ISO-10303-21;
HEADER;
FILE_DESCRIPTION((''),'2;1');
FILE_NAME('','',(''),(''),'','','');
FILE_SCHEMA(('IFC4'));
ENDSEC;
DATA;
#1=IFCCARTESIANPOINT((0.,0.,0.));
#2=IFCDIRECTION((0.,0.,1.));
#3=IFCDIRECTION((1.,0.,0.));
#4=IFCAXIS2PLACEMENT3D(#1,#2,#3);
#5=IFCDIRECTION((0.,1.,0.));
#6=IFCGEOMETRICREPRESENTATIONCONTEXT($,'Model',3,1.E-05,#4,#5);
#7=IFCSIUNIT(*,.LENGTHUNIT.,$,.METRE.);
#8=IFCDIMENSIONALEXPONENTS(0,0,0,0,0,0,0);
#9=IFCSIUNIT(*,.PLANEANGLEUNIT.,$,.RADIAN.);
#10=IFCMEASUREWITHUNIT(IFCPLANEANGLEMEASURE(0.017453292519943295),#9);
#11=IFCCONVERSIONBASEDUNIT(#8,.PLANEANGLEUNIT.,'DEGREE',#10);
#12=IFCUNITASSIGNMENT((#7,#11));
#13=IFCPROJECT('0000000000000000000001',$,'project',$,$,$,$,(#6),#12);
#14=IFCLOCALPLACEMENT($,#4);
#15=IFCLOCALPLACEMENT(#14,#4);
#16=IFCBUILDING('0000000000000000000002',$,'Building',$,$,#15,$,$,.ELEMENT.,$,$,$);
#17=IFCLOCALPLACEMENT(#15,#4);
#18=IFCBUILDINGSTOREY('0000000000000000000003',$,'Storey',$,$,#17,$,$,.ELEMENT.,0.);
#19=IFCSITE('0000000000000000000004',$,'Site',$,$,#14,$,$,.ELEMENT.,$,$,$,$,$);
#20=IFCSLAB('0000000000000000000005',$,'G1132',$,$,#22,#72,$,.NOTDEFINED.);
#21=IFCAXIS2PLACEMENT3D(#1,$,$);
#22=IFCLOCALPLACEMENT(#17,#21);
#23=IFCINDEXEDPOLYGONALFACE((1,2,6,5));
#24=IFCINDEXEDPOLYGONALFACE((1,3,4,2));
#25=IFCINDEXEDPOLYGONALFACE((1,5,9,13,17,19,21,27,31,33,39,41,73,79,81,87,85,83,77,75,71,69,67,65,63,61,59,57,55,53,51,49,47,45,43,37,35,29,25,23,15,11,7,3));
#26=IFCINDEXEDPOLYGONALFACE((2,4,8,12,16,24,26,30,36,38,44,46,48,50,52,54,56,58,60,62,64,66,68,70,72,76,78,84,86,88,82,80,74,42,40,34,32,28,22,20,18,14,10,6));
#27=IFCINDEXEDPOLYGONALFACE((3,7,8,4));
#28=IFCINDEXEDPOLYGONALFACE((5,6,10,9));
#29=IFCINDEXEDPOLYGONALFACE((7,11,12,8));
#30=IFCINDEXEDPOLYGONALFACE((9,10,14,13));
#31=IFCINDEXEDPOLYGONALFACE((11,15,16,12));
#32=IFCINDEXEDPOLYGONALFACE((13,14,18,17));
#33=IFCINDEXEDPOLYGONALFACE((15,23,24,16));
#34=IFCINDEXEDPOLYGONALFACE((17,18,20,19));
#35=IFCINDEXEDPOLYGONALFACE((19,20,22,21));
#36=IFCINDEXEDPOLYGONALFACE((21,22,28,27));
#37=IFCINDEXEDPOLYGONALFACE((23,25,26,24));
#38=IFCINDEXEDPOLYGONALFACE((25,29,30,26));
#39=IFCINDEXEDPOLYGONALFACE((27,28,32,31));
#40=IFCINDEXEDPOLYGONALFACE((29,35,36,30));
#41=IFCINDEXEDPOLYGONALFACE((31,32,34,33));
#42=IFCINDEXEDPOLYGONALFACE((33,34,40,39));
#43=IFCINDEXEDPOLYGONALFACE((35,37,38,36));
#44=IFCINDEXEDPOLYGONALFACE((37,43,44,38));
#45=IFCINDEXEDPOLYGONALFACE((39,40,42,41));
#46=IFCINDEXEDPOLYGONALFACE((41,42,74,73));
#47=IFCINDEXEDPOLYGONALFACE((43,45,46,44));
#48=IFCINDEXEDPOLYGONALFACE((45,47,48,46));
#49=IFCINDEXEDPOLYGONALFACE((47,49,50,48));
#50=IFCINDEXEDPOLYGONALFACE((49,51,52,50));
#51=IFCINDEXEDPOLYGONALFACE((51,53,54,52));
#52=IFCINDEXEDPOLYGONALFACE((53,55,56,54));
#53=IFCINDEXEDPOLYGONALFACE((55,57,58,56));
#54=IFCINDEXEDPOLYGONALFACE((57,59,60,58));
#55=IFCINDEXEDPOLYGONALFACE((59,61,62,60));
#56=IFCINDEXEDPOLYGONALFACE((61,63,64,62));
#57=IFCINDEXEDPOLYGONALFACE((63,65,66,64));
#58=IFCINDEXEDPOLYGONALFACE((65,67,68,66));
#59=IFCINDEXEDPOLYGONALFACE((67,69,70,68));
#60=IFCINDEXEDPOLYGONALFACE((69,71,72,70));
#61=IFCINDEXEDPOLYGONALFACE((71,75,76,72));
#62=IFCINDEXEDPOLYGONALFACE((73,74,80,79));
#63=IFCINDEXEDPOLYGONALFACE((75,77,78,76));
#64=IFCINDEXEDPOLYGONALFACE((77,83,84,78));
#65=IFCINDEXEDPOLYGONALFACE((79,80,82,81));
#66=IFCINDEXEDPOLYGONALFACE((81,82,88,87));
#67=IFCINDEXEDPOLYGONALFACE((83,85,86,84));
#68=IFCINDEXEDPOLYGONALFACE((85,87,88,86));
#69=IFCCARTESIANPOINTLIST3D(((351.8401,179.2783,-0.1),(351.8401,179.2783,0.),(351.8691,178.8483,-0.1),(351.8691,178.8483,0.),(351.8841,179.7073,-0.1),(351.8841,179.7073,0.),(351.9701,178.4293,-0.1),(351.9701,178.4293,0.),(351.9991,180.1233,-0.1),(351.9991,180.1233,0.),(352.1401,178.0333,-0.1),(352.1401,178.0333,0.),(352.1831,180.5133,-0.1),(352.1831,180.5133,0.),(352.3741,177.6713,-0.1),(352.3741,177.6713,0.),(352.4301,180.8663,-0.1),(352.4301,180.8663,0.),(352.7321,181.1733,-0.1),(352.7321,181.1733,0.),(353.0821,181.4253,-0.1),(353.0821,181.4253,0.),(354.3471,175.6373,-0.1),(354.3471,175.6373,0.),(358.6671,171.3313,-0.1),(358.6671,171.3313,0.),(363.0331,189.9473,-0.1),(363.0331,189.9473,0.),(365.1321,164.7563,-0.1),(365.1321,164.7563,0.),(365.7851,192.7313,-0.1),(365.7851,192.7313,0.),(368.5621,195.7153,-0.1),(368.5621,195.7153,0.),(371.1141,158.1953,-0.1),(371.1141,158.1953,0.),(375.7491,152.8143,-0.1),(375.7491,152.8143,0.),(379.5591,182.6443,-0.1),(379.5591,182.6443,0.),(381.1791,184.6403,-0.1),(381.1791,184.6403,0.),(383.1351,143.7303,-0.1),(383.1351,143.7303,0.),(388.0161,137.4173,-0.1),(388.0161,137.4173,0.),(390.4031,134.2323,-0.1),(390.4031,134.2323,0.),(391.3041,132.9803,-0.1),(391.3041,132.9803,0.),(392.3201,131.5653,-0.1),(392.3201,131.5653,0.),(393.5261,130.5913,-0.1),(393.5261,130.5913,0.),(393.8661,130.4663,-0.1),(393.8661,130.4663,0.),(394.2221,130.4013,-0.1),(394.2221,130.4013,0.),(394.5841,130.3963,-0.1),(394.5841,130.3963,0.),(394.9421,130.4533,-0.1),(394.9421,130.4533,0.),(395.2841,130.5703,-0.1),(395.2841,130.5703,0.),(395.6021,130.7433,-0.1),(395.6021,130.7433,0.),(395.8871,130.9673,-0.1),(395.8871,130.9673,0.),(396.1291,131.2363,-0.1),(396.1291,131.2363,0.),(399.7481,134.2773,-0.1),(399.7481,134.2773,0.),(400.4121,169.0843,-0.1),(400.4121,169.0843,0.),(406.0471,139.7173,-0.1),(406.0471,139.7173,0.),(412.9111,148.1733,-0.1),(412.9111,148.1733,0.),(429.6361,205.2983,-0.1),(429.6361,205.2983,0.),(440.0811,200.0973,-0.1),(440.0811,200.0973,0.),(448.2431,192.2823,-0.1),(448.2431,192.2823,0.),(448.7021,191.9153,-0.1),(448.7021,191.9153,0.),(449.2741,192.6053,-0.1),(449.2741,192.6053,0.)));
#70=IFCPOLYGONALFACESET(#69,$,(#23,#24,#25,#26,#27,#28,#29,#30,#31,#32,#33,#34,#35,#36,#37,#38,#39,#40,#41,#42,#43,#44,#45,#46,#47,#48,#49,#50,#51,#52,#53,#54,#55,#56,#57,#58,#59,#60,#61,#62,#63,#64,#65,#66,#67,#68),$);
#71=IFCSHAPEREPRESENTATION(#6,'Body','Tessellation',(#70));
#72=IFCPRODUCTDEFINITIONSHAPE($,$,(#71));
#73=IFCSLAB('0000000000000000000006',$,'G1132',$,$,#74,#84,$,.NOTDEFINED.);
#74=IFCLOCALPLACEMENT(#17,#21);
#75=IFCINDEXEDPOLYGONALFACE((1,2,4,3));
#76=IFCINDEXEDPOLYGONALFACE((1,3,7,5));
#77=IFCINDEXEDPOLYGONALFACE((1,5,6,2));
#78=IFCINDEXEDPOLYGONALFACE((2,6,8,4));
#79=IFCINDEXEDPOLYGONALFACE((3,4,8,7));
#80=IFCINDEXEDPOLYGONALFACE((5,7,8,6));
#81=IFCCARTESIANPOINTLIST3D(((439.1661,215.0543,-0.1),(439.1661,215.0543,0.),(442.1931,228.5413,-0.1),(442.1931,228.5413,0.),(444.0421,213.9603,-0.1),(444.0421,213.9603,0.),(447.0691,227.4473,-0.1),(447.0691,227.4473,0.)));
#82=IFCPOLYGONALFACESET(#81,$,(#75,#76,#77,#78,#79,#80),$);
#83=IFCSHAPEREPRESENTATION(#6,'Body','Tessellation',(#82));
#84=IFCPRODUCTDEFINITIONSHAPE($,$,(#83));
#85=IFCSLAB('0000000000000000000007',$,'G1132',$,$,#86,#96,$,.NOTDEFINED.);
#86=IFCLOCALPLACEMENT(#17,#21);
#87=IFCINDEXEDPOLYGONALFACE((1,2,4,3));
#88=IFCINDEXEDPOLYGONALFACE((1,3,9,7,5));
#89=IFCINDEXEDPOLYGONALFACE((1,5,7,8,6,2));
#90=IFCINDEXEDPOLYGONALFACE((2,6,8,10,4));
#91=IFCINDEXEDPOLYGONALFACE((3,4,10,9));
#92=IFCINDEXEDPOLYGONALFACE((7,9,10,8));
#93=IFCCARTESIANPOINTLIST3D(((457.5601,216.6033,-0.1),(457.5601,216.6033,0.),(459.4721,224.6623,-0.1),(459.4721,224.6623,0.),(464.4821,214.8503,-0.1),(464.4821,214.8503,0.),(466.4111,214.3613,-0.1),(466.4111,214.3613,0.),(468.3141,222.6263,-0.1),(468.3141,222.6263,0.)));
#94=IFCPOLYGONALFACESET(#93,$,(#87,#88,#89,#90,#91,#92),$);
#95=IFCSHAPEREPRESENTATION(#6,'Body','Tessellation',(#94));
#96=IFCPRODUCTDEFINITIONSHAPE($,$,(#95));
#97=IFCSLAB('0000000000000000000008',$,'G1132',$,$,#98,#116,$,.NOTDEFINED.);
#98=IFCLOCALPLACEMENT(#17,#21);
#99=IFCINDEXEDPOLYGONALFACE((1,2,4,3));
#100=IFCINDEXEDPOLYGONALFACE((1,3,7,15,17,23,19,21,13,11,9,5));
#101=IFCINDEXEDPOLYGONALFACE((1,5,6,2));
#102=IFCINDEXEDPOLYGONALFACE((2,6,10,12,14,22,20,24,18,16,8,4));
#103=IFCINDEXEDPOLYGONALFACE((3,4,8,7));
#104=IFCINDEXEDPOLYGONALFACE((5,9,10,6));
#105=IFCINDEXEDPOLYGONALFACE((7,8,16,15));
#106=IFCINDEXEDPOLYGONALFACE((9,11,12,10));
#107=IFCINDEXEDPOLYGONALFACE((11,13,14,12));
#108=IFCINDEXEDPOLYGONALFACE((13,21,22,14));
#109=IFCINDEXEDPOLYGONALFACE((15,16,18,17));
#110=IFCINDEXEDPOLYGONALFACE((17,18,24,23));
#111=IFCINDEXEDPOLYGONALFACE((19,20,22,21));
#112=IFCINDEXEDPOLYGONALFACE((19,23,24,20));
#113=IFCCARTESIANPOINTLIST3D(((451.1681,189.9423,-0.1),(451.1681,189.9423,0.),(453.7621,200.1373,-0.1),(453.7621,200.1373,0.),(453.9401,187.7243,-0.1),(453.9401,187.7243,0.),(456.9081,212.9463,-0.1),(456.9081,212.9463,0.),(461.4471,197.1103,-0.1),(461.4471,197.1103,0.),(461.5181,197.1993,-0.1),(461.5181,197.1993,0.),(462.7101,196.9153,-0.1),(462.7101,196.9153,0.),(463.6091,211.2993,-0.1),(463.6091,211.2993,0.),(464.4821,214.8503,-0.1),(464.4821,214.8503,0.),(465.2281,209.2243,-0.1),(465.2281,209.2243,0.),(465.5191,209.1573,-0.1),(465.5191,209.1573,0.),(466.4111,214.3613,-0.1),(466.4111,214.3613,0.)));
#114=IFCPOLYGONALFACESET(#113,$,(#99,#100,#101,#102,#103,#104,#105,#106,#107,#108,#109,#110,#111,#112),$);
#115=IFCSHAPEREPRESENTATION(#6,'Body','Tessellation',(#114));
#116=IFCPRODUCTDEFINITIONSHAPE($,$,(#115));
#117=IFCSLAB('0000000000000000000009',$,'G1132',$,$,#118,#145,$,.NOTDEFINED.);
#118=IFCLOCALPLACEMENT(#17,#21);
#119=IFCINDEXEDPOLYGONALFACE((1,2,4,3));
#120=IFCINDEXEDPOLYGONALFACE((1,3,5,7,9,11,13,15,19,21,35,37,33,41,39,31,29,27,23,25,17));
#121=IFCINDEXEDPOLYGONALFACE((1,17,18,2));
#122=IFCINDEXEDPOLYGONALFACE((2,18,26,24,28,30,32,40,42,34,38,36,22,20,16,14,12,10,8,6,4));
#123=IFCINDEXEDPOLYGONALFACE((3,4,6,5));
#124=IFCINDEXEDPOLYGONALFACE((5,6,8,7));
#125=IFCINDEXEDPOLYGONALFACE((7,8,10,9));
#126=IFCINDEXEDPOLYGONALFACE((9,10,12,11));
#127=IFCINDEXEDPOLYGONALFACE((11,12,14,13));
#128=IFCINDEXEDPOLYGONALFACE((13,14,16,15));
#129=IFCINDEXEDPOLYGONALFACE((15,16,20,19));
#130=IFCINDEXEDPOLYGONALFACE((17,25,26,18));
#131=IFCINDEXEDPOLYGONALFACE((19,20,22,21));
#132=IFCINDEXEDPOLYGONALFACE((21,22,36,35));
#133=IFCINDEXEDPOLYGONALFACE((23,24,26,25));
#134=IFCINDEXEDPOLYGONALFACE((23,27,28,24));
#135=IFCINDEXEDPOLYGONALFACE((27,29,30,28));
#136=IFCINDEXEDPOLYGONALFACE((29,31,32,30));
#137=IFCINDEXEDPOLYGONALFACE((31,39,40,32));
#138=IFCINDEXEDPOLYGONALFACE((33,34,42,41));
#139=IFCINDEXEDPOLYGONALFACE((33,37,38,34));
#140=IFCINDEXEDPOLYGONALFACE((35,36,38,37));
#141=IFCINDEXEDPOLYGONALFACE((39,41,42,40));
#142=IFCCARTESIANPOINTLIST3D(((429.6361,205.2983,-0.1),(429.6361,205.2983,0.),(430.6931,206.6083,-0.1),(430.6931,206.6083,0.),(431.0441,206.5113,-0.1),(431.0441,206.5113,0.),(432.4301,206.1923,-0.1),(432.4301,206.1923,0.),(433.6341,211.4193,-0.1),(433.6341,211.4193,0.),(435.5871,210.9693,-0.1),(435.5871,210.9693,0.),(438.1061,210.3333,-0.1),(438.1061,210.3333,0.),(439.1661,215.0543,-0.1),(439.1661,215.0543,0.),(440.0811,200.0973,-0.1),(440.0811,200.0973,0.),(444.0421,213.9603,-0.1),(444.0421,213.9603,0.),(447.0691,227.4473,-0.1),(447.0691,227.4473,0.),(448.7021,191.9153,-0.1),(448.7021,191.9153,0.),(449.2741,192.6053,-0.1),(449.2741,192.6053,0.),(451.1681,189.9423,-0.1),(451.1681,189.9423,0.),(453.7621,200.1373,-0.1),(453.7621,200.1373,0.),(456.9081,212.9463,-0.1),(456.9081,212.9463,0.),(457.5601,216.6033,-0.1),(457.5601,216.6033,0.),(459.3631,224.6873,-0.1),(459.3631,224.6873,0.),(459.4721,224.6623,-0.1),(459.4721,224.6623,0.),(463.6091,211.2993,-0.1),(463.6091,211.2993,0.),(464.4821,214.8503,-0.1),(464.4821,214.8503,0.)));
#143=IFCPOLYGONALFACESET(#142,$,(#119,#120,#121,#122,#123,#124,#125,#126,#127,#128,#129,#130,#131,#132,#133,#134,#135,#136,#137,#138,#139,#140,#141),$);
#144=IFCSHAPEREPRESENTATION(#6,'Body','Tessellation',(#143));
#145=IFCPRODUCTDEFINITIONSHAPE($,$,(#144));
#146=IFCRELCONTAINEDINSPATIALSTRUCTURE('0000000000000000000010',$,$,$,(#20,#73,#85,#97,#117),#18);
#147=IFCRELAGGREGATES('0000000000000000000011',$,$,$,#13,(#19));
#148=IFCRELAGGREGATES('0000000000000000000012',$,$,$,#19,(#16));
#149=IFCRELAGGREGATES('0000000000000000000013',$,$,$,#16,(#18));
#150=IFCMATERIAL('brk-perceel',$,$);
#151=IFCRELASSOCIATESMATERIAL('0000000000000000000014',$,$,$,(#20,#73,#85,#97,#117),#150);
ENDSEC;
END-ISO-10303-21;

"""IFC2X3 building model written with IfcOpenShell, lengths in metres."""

from ifc_helpers import new_model, entity, si_unit, converted_unit, direction, frame, origin_with_axes, place, context, project, spatial, polyline, outline, extrude, material, element, save


model = new_model("IFC2X3")

# Units and contexts
model_context = context("Model", 3, precision=1e-05, world=origin_with_axes(), true_north=direction((0.0, 1.0, 0.0)))
ifc_project = project(units=[si_unit("LENGTHUNIT", "METRE"), converted_unit("PLANEANGLEUNIT", "DEGREE", entity("IfcPlaneAngleMeasure", 0.017453292519943295), si_unit("PLANEANGLEUNIT", "RADIAN"), dimensions=[0, 0, 0, 0, 0, 0, 0])], contexts=[model_context])

# Site, building, storey
site_placement = place(None, origin_with_axes())
site = spatial("IfcSite", under=ifc_project, at=site_placement, Name="Site", CompositionType="ELEMENT")
building_placement = place(site_placement, origin_with_axes())
building = spatial("IfcBuilding", under=site, at=building_placement, Name="Building", CompositionType="ELEMENT")
storey_placement = place(building_placement, origin_with_axes())
storey = spatial("IfcBuildingStorey", under=building, at=storey_placement, Name="Storey", CompositionType="ELEMENT", Elevation=0.0)

# Slabs
ifc_material = material(Name="brk-perceel")
slab_1_placement = place(storey_placement, frame((0.0, 0.0, -0.1), z_axis=(0.0, 0.0, 1.0), x_axis=(1.0, 0.0, 0.0)))
element("IfcSlab", 1, at=slab_1_placement, inside=storey, material=ifc_material, Name="G1132", PredefinedType="NOTDEFINED", context=model_context, shape_type="SweptSolid", body=[
    extrude(outline(polyline([(448.2431, 192.2823), (412.9111, 148.1733), (406.0471, 139.7173), (399.7481, 134.2773), (396.1291, 131.2363), (395.8871, 130.9673), (395.6021, 130.7433), (395.2841, 130.5703), (394.9421, 130.4533), (394.5841, 130.3963), (394.2221, 130.4013), (393.8661, 130.4663), (393.5261, 130.5913), (392.3201, 131.5653), (391.3041, 132.9803), (390.4031, 134.2323), (388.0161, 137.4173), (383.1351, 143.7303), (375.7491, 152.8143), (371.1141, 158.1953), (365.1321, 164.7563), (358.6671, 171.3313), (354.3471, 175.6373), (352.3741, 177.6713), (352.1401, 178.0333), (351.9701, 178.4293), (351.8691, 178.8483), (351.8401, 179.2783), (351.8841, 179.7073), (351.9991, 180.1233), (352.1831, 180.5133), (352.4301, 180.8663), (352.7321, 181.1733), (353.0821, 181.4253), (363.0331, 189.9473), (365.7851, 192.7313), (368.5621, 195.7153), (379.5591, 182.6443), (381.1791, 184.6403), (400.4121, 169.0843), (429.6361, 205.2983), (440.0811, 200.0973), (449.2741, 192.6053), (448.7021, 191.9153), (448.2431, 192.2823)])), origin_with_axes(), (0.0, 0.0, 1.0), 0.1),
])
slab_2_placement = place(storey_placement, frame((0.0, 0.0, -0.1), z_axis=(0.0, 0.0, 1.0), x_axis=(1.0, 0.0, 0.0)))
element("IfcSlab", 2, at=slab_2_placement, inside=storey, material=ifc_material, Name="G1132", PredefinedType="NOTDEFINED", context=model_context, shape_type="SweptSolid", body=[
    extrude(outline(polyline([(444.0421, 213.9603), (439.1661, 215.0543), (442.1931, 228.5413), (447.0691, 227.4473), (444.0421, 213.9603)])), origin_with_axes(), (0.0, 0.0, 1.0), 0.1),
])
slab_3_placement = place(storey_placement, frame((0.0, 0.0, -0.1), z_axis=(0.0, 0.0, 1.0), x_axis=(1.0, 0.0, 0.0)))
element("IfcSlab", 3, at=slab_3_placement, inside=storey, material=ifc_material, Name="G1132", PredefinedType="NOTDEFINED", context=model_context, shape_type="SweptSolid", body=[
    extrude(outline(polyline([(464.4821, 214.8503), (457.5601, 216.6033), (459.4721, 224.6623), (468.3141, 222.6263), (466.4111, 214.3613), (464.4821, 214.8503)])), origin_with_axes(), (0.0, 0.0, 1.0), 0.1),
])
slab_4_placement = place(storey_placement, frame((0.0, 0.0, -0.1), z_axis=(0.0, 0.0, 1.0), x_axis=(1.0, 0.0, 0.0)))
element("IfcSlab", 4, at=slab_4_placement, inside=storey, material=ifc_material, Name="G1132", PredefinedType="NOTDEFINED", context=model_context, shape_type="SweptSolid", body=[
    extrude(outline(polyline([(464.4821, 214.8503), (466.4111, 214.3613), (465.2281, 209.2243), (465.5191, 209.1573), (462.7101, 196.9153), (461.5181, 197.1993), (461.4471, 197.1103), (453.9401, 187.7243), (451.1681, 189.9423), (453.7621, 200.1373), (456.9081, 212.9463), (463.6091, 211.2993), (464.4821, 214.8503)])), origin_with_axes(), (0.0, 0.0, 1.0), 0.1),
])
slab_5_placement = place(storey_placement, frame((0.0, 0.0, -0.1), z_axis=(0.0, 0.0, 1.0), x_axis=(1.0, 0.0, 0.0)))
element("IfcSlab", 5, at=slab_5_placement, inside=storey, material=ifc_material, Name="G1132", PredefinedType="NOTDEFINED", context=model_context, shape_type="SweptSolid", body=[
    extrude(outline(polyline([(463.6091, 211.2993), (456.9081, 212.9463), (453.7621, 200.1373), (451.1681, 189.9423), (448.7021, 191.9153), (449.2741, 192.6053), (440.0811, 200.0973), (429.6361, 205.2983), (430.6931, 206.6083), (431.0441, 206.5113), (432.4301, 206.1923), (433.6341, 211.4193), (435.5871, 210.9693), (438.1061, 210.3333), (439.1661, 215.0543), (444.0421, 213.9603), (447.0691, 227.4473), (459.3631, 224.6873), (459.4721, 224.6623), (457.5601, 216.6033), (464.4821, 214.8503), (463.6091, 211.2993)])), origin_with_axes(), (0.0, 0.0, 1.0), 0.1),
])

save(model, "model.ifc")
